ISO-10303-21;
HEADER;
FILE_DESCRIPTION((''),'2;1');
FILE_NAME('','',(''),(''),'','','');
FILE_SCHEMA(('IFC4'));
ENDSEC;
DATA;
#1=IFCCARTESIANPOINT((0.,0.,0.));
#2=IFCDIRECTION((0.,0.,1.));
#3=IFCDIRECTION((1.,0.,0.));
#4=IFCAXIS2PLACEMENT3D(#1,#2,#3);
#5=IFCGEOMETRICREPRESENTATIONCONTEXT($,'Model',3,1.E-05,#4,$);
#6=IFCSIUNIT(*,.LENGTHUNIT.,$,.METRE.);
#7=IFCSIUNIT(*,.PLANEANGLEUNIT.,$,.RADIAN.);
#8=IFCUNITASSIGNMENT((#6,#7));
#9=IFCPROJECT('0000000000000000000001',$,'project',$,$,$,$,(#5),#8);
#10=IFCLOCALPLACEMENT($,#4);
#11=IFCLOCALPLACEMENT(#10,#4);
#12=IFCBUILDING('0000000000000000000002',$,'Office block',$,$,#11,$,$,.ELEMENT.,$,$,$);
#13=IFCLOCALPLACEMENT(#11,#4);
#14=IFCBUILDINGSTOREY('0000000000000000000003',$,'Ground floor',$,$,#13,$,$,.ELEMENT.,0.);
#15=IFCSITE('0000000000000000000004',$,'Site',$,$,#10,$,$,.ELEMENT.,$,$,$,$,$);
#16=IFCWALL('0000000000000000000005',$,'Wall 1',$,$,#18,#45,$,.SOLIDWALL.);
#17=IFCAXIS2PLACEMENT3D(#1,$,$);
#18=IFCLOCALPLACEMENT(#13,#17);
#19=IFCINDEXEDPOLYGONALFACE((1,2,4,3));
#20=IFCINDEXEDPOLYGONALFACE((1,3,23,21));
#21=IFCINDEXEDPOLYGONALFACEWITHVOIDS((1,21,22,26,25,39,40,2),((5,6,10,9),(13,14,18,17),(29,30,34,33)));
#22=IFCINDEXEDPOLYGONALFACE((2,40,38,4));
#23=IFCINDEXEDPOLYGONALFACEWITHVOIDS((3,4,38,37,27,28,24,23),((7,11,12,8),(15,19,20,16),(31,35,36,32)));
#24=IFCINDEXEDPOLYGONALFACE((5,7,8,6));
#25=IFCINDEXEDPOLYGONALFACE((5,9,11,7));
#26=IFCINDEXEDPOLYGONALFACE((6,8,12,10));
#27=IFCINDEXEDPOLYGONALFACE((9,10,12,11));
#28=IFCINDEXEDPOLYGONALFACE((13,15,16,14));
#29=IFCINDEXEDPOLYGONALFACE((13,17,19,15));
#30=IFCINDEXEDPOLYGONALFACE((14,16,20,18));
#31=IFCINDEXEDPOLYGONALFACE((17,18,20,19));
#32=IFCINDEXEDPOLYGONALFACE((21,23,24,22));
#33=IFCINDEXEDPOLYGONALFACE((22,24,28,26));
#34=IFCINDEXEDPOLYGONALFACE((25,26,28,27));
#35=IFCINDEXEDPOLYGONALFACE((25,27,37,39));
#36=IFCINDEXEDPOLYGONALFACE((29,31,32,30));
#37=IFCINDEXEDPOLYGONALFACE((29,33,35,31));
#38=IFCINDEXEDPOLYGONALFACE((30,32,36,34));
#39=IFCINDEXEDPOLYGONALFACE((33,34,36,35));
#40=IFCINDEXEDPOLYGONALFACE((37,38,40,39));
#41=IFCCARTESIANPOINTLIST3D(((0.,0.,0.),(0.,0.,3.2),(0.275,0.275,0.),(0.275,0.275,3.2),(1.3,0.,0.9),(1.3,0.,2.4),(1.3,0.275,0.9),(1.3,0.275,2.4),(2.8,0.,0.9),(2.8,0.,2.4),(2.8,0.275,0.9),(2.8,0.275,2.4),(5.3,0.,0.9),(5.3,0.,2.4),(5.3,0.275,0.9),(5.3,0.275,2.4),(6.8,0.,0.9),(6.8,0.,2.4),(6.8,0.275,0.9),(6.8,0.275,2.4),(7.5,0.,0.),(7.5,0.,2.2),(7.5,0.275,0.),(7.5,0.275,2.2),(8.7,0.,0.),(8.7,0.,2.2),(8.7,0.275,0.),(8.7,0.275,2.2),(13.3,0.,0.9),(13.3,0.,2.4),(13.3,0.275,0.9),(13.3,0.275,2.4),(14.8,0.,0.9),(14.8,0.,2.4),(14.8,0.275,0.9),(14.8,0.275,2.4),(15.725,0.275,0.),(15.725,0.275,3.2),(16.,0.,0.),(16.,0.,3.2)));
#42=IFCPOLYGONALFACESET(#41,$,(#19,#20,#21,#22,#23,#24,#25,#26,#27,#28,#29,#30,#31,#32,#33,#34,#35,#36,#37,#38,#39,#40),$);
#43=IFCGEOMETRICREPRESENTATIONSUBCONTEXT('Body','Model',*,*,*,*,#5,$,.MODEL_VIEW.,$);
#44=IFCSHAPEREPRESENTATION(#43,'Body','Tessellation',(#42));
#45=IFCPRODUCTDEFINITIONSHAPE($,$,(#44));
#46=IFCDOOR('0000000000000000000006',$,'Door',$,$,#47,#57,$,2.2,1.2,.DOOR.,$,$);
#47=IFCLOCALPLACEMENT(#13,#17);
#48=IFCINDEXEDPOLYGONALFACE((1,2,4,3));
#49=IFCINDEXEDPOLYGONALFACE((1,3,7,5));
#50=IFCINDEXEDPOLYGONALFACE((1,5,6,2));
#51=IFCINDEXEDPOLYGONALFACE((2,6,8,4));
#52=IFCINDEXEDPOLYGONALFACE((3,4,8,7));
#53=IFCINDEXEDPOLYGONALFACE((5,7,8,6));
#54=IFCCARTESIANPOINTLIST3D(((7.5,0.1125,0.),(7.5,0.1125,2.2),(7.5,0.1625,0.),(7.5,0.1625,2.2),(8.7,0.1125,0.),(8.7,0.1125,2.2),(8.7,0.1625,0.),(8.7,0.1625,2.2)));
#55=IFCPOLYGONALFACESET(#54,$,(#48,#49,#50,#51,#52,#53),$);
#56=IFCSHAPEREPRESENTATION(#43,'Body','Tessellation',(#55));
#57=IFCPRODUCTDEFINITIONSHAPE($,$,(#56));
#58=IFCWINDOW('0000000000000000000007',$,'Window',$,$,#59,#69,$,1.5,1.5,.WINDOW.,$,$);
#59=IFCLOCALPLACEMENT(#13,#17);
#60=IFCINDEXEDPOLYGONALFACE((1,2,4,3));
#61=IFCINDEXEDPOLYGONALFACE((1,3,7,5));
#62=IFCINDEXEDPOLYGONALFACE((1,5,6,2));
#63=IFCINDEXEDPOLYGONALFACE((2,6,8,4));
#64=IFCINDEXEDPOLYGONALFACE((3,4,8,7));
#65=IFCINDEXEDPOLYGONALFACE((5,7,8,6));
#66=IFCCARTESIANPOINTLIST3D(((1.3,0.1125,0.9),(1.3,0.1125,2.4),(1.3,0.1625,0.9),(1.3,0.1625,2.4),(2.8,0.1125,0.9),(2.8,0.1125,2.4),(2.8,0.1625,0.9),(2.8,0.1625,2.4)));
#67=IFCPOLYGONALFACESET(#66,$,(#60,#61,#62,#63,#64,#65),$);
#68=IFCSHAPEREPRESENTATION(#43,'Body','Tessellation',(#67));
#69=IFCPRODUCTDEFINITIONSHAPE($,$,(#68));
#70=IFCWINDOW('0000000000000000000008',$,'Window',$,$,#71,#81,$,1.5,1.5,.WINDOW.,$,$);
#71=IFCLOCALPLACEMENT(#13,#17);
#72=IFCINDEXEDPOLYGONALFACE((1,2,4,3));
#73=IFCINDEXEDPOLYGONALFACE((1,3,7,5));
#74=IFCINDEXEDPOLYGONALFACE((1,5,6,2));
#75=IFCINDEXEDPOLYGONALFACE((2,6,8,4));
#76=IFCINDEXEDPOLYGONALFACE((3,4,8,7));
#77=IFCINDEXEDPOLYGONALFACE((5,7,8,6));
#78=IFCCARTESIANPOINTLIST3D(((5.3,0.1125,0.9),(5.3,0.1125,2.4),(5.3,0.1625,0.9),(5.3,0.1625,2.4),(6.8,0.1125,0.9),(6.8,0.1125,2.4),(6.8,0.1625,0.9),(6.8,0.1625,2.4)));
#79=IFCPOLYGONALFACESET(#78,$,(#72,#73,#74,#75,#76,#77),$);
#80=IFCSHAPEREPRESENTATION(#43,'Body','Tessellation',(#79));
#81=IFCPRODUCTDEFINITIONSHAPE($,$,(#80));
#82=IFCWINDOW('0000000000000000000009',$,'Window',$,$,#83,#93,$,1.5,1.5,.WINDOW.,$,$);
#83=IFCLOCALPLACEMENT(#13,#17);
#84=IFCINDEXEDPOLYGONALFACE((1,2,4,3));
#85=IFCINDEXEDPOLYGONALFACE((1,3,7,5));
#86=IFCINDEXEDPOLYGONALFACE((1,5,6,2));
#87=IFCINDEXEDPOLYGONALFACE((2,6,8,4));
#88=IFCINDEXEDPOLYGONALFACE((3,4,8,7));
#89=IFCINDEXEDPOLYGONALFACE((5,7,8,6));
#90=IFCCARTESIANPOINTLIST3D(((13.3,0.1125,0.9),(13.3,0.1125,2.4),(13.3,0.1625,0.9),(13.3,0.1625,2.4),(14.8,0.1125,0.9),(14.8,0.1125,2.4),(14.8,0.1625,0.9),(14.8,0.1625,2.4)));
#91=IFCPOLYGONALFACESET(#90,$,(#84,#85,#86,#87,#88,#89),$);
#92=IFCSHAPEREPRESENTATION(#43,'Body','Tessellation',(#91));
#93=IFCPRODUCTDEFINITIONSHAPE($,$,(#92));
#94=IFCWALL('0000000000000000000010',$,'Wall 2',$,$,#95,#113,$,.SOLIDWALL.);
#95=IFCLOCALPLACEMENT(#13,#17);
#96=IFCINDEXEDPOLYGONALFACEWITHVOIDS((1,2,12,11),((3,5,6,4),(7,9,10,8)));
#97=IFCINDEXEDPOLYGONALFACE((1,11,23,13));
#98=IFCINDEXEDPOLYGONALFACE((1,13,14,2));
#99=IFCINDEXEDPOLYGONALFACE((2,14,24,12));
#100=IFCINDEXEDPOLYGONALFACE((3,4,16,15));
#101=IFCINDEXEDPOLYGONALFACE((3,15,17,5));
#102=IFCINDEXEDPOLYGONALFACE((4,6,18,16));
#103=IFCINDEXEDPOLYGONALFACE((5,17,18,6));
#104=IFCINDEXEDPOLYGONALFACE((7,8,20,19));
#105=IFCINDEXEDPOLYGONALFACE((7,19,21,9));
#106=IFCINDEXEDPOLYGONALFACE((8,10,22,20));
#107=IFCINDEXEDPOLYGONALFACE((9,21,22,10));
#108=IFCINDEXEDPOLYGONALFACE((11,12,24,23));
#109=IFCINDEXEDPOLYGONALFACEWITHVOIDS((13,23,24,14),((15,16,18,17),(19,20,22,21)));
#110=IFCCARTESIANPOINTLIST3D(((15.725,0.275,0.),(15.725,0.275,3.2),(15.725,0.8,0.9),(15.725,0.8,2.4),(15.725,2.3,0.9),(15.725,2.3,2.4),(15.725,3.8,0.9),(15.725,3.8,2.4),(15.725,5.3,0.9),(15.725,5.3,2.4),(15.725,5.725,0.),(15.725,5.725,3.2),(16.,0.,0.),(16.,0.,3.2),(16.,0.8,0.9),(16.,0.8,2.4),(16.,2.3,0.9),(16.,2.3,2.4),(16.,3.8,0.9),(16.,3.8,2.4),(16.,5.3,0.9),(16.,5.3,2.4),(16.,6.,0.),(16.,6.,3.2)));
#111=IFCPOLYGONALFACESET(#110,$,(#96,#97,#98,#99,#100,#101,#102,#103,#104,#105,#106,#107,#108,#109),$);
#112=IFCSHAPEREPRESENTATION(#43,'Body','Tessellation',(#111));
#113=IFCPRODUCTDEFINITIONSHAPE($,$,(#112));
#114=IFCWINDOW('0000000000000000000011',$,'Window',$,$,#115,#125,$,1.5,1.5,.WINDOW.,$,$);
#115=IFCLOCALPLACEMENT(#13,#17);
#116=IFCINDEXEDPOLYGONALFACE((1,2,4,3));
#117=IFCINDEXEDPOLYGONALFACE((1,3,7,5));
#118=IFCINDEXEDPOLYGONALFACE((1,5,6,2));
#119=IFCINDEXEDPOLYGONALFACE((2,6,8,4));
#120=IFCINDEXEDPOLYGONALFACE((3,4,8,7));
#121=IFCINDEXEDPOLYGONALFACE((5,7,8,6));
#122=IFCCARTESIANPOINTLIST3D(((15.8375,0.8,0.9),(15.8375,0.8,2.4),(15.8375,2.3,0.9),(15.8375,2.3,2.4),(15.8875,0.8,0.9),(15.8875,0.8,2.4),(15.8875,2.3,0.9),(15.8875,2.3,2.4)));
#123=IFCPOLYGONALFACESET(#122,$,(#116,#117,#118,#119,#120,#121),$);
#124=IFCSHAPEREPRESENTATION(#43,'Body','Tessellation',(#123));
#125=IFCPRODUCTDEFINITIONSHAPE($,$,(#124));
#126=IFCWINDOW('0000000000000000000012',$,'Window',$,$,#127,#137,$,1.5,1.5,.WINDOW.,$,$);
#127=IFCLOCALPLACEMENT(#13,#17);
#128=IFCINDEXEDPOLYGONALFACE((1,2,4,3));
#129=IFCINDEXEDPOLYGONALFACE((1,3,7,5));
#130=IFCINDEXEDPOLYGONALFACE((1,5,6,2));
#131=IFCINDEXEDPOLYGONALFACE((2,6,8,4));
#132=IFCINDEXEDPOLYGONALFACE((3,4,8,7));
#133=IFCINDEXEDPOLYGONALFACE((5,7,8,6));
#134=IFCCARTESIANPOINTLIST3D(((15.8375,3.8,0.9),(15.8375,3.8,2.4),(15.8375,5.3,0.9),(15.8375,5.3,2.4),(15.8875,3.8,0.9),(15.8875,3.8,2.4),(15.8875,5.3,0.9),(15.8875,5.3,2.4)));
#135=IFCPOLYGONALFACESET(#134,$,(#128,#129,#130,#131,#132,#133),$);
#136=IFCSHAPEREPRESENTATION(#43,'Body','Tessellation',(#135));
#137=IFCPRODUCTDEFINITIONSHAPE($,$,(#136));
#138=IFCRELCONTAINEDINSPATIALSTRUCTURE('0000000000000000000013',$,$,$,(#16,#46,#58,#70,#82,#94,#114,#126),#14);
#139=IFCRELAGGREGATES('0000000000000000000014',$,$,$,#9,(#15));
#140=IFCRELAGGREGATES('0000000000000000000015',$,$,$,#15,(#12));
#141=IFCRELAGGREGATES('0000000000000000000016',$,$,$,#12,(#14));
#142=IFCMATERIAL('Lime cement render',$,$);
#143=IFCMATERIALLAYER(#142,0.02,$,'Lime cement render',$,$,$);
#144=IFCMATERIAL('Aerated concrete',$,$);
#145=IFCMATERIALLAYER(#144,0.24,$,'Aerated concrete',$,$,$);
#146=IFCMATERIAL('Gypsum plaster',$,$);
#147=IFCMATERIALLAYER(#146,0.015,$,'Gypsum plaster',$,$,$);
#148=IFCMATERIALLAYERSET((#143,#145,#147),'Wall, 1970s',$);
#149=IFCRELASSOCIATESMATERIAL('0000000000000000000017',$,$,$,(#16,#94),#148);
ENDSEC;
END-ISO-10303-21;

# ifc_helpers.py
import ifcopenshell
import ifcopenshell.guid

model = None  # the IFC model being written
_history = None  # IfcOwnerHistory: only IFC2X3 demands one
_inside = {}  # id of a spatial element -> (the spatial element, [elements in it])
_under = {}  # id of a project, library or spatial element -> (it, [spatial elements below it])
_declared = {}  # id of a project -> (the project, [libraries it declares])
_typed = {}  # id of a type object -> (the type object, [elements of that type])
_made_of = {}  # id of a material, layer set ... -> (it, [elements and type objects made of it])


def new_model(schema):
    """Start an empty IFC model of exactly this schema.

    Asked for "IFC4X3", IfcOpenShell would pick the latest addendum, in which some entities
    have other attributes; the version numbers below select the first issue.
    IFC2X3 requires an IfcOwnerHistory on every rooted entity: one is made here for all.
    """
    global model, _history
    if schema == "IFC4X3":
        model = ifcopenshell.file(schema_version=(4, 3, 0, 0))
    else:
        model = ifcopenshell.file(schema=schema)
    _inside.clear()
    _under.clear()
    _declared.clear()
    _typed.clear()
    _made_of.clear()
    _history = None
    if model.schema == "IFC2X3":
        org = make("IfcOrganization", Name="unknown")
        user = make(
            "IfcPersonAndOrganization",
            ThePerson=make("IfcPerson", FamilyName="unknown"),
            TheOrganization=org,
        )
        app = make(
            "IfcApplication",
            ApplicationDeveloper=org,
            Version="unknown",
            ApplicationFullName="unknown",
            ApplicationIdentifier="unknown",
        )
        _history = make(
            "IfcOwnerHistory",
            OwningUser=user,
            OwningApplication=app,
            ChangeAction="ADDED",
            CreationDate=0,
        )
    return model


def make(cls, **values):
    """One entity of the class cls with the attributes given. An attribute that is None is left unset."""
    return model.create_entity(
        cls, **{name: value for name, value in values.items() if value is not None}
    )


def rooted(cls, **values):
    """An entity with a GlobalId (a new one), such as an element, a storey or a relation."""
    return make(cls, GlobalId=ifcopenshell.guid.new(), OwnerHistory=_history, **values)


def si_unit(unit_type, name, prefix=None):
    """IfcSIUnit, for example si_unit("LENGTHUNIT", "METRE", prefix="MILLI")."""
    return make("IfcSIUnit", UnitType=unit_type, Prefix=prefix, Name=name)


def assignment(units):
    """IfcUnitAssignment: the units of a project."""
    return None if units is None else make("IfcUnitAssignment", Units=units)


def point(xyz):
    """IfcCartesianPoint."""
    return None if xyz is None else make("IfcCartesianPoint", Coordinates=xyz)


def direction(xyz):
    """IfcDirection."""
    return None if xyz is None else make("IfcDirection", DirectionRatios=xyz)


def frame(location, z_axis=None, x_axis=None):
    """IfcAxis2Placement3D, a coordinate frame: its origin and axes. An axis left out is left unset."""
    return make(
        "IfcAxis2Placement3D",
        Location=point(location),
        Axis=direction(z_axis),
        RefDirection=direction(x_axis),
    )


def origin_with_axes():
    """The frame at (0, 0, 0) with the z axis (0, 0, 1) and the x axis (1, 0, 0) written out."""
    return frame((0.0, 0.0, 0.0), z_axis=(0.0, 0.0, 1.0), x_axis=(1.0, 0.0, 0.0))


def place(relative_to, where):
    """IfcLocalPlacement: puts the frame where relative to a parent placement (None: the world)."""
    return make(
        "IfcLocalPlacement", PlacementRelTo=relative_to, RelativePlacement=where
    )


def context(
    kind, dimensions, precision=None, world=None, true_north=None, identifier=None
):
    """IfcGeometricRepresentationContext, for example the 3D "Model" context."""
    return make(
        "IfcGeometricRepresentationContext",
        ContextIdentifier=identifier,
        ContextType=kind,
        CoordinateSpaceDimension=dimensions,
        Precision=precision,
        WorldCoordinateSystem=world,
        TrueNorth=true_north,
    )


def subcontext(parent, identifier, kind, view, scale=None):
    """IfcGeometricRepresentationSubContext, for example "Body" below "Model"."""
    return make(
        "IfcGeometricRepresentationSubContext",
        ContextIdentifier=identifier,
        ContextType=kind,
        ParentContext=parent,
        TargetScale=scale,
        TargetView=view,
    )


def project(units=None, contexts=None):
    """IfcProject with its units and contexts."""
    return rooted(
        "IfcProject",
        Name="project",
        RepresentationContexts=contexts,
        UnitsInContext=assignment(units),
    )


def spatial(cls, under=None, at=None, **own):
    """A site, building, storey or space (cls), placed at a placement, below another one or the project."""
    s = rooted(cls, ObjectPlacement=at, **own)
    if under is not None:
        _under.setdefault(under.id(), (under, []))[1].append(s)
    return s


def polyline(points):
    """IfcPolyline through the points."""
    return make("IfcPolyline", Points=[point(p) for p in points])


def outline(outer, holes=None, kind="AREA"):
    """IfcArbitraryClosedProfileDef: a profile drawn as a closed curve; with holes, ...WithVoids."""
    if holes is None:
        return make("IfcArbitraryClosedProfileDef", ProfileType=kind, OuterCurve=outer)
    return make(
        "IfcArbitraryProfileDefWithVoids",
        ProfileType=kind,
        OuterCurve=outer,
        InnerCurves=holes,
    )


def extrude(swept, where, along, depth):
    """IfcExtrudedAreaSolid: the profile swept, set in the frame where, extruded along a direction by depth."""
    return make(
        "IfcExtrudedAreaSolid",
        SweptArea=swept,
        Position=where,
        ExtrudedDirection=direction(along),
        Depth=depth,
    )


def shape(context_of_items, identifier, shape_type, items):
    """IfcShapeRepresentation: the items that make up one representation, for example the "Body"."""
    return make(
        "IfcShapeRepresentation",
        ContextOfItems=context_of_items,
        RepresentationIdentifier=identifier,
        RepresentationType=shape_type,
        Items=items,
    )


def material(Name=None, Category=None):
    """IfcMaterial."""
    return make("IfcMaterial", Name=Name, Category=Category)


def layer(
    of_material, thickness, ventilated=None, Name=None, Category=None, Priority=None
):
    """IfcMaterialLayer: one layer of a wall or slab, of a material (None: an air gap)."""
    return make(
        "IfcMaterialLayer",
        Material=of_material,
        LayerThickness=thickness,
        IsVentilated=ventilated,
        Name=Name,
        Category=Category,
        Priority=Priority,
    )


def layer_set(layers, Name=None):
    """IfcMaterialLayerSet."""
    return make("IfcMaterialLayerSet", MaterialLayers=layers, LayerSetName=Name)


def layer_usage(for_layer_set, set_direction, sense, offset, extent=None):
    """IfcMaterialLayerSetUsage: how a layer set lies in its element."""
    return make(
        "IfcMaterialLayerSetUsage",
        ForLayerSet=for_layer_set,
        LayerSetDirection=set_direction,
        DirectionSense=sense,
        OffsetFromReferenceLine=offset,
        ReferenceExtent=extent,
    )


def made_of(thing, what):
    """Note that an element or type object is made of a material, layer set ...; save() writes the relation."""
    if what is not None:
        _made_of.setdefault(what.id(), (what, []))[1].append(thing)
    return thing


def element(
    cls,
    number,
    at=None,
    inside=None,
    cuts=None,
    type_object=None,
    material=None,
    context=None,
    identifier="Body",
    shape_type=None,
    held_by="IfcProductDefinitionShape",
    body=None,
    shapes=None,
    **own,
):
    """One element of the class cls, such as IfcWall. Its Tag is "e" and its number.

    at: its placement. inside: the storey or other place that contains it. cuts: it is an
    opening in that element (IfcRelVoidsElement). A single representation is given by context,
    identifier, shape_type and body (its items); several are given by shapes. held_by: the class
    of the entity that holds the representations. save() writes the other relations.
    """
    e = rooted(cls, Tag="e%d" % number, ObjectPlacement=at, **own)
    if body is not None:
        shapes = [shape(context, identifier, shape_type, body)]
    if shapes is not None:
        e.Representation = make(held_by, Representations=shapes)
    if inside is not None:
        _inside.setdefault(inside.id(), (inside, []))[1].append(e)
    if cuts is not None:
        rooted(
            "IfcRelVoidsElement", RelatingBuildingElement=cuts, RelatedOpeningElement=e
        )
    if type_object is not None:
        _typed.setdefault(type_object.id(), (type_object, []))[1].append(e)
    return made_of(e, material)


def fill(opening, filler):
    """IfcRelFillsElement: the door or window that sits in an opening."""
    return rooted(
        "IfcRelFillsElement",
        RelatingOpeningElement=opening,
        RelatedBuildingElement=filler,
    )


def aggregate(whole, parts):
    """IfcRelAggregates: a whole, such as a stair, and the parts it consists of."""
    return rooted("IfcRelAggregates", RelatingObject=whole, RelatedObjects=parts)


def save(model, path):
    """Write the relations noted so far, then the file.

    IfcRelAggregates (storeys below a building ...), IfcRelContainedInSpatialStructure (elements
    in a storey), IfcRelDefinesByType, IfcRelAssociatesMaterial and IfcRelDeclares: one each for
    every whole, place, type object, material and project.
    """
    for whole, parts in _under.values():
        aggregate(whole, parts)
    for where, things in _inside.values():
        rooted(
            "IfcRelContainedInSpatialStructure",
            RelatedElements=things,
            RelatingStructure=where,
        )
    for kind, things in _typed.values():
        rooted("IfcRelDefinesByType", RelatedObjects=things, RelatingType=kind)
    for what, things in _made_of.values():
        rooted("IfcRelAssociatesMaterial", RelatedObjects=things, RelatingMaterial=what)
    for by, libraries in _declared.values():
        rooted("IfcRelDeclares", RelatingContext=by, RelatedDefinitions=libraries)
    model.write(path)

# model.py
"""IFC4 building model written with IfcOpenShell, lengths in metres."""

from ifc_helpers import new_model, si_unit, frame, origin_with_axes, place, context, subcontext, project, spatial, polyline, outline, extrude, material, layer, layer_set, layer_usage, element, fill, save


model = new_model("IFC4")

# Units and contexts
model_context = context("Model", 3, precision=1e-05, world=origin_with_axes())
body_context = subcontext(model_context, "Body", "Model", "MODEL_VIEW")
ifc_project = project(units=[si_unit("LENGTHUNIT", "METRE"), si_unit("PLANEANGLEUNIT", "RADIAN")], contexts=[model_context])

# Site, building, storey
site_placement = place(None, origin_with_axes())
site = spatial("IfcSite", under=ifc_project, at=site_placement, Name="Site", CompositionType="ELEMENT")
building_placement = place(site_placement, origin_with_axes())
building = spatial("IfcBuilding", under=site, at=building_placement, Name="Office block", CompositionType="ELEMENT")
storey_placement = place(building_placement, origin_with_axes())
storey = spatial("IfcBuildingStorey", under=building, at=storey_placement, Name="Ground floor", CompositionType="ELEMENT", Elevation=0.0)

# Wall, openings, door, windows
ifc_material_1 = material(Name="Lime cement render")
ifc_layer_1 = layer(ifc_material_1, 0.02, Name="Lime cement render")
ifc_material_2 = material(Name="Aerated concrete")
ifc_layer_2 = layer(ifc_material_2, 0.24, Name="Aerated concrete")
ifc_material_3 = material(Name="Gypsum plaster")
ifc_layer_3 = layer(ifc_material_3, 0.015, Name="Gypsum plaster")
ifc_layer_set = layer_set([ifc_layer_1, ifc_layer_2, ifc_layer_3], Name="Wall, 1970s")
ifc_layer_usage_1 = layer_usage(ifc_layer_set, "AXIS2", "NEGATIVE", 0.0)
wall_1_placement = place(storey_placement, origin_with_axes())
wall_1 = element("IfcWall", 1, at=wall_1_placement, inside=storey, material=ifc_layer_usage_1, Name="Wall 1", PredefinedType="SOLIDWALL", context=body_context, shape_type="SweptSolid", body=[
    extrude(outline(polyline([(0.0, 0.0), (16.0, 0.0), (15.725, 0.275), (0.275, 0.275), (0.0, 0.0)])), origin_with_axes(), (0.0, 0.0, 1.0), 3.2),
])
opening_1_placement = place(storey_placement, origin_with_axes())
opening_1 = element("IfcOpeningElement", 2, at=opening_1_placement, cuts=wall_1, PredefinedType="OPENING", context=body_context, shape_type="SweptSolid", body=[
    extrude(outline(polyline([(7.5, -0.01), (8.7, -0.01), (8.7, 0.285), (7.5, 0.285), (7.5, -0.01)])), origin_with_axes(), (0.0, 0.0, 1.0), 2.2),
])
opening_2_placement = place(storey_placement, origin_with_axes())
opening_2 = element("IfcOpeningElement", 3, at=opening_2_placement, cuts=wall_1, PredefinedType="OPENING", context=body_context, shape_type="SweptSolid", body=[
    extrude(outline(polyline([(1.3, -0.01), (2.8, -0.01), (2.8, 0.285), (1.3, 0.285), (1.3, -0.01)])), frame((0.0, 0.0, 0.9), z_axis=(0.0, 0.0, 1.0), x_axis=(1.0, 0.0, 0.0)), (0.0, 0.0, 1.0), 1.5),
])
opening_3_placement = place(storey_placement, origin_with_axes())
opening_3 = element("IfcOpeningElement", 4, at=opening_3_placement, cuts=wall_1, PredefinedType="OPENING", context=body_context, shape_type="SweptSolid", body=[
    extrude(outline(polyline([(5.3, -0.01), (6.8, -0.01), (6.8, 0.285), (5.3, 0.285), (5.3, -0.01)])), frame((0.0, 0.0, 0.9), z_axis=(0.0, 0.0, 1.0), x_axis=(1.0, 0.0, 0.0)), (0.0, 0.0, 1.0), 1.5),
])
opening_4_placement = place(storey_placement, origin_with_axes())
opening_4 = element("IfcOpeningElement", 5, at=opening_4_placement, cuts=wall_1, PredefinedType="OPENING", context=body_context, shape_type="SweptSolid", body=[
    extrude(outline(polyline([(13.3, -0.01), (14.8, -0.01), (14.8, 0.285), (13.3, 0.285), (13.3, -0.01)])), frame((0.0, 0.0, 0.9), z_axis=(0.0, 0.0, 1.0), x_axis=(1.0, 0.0, 0.0)), (0.0, 0.0, 1.0), 1.5),
])
door_placement = place(storey_placement, origin_with_axes())
door = element("IfcDoor", 6, at=door_placement, inside=storey, Name="Door", OverallHeight=2.2, OverallWidth=1.2, PredefinedType="DOOR", context=body_context, shape_type="SweptSolid", body=[
    extrude(outline(polyline([(7.5, 0.1125), (8.7, 0.1125), (8.7, 0.1625), (7.5, 0.1625), (7.5, 0.1125)])), origin_with_axes(), (0.0, 0.0, 1.0), 2.2),
])
fill(opening_1, door)
window_1_placement = place(storey_placement, origin_with_axes())
window_1 = element("IfcWindow", 7, at=window_1_placement, inside=storey, Name="Window", OverallHeight=1.5, OverallWidth=1.5, PredefinedType="WINDOW", context=body_context, shape_type="SweptSolid", body=[
    extrude(outline(polyline([(1.3, 0.1125), (2.8, 0.1125), (2.8, 0.1625), (1.3, 0.1625), (1.3, 0.1125)])), frame((0.0, 0.0, 0.9), z_axis=(0.0, 0.0, 1.0), x_axis=(1.0, 0.0, 0.0)), (0.0, 0.0, 1.0), 1.5),
])
fill(opening_2, window_1)
window_2_placement = place(storey_placement, origin_with_axes())
window_2 = element("IfcWindow", 8, at=window_2_placement, inside=storey, Name="Window", OverallHeight=1.5, OverallWidth=1.5, PredefinedType="WINDOW", context=body_context, shape_type="SweptSolid", body=[
    extrude(outline(polyline([(5.3, 0.1125), (6.8, 0.1125), (6.8, 0.1625), (5.3, 0.1625), (5.3, 0.1125)])), frame((0.0, 0.0, 0.9), z_axis=(0.0, 0.0, 1.0), x_axis=(1.0, 0.0, 0.0)), (0.0, 0.0, 1.0), 1.5),
])
fill(opening_3, window_2)
window_3_placement = place(storey_placement, origin_with_axes())
window_3 = element("IfcWindow", 9, at=window_3_placement, inside=storey, Name="Window", OverallHeight=1.5, OverallWidth=1.5, PredefinedType="WINDOW", context=body_context, shape_type="SweptSolid", body=[
    extrude(outline(polyline([(13.3, 0.1125), (14.8, 0.1125), (14.8, 0.1625), (13.3, 0.1625), (13.3, 0.1125)])), frame((0.0, 0.0, 0.9), z_axis=(0.0, 0.0, 1.0), x_axis=(1.0, 0.0, 0.0)), (0.0, 0.0, 1.0), 1.5),
])
fill(opening_4, window_3)

# Wall, openings, windows
ifc_layer_usage_2 = layer_usage(ifc_layer_set, "AXIS2", "NEGATIVE", 0.0)
wall_2_placement = place(storey_placement, origin_with_axes())
wall_2 = element("IfcWall", 10, at=wall_2_placement, inside=storey, material=ifc_layer_usage_2, Name="Wall 2", PredefinedType="SOLIDWALL", context=body_context, shape_type="SweptSolid", body=[
    extrude(outline(polyline([(16.0, 0.0), (16.0, 6.0), (15.725, 5.725), (15.725, 0.275), (16.0, 0.0)])), origin_with_axes(), (0.0, 0.0, 1.0), 3.2),
])
opening_5_placement = place(storey_placement, origin_with_axes())
opening_5 = element("IfcOpeningElement", 11, at=opening_5_placement, cuts=wall_2, PredefinedType="OPENING", context=body_context, shape_type="SweptSolid", body=[
    extrude(outline(polyline([(16.01, 0.8), (16.01, 2.3), (15.715, 2.3), (15.715, 0.8), (16.01, 0.8)])), frame((0.0, 0.0, 0.9), z_axis=(0.0, 0.0, 1.0), x_axis=(1.0, 0.0, 0.0)), (0.0, 0.0, 1.0), 1.5),
])
opening_6_placement = place(storey_placement, origin_with_axes())
opening_6 = element("IfcOpeningElement", 12, at=opening_6_placement, cuts=wall_2, PredefinedType="OPENING", context=body_context, shape_type="SweptSolid", body=[
    extrude(outline(polyline([(16.01, 3.8), (16.01, 5.3), (15.715, 5.3), (15.715, 3.8), (16.01, 3.8)])), frame((0.0, 0.0, 0.9), z_axis=(0.0, 0.0, 1.0), x_axis=(1.0, 0.0, 0.0)), (0.0, 0.0, 1.0), 1.5),
])
window_4_placement = place(storey_placement, origin_with_axes())
window_4 = element("IfcWindow", 13, at=window_4_placement, inside=storey, Name="Window", OverallHeight=1.5, OverallWidth=1.5, PredefinedType="WINDOW", context=body_context, shape_type="SweptSolid", body=[
    extrude(outline(polyline([(15.8875, 0.8), (15.8875, 2.3), (15.8375, 2.3), (15.8375, 0.8), (15.8875, 0.8)])), frame((0.0, 0.0, 0.9), z_axis=(0.0, 0.0, 1.0), x_axis=(1.0, 0.0, 0.0)), (0.0, 0.0, 1.0), 1.5),
])
fill(opening_5, window_4)
window_5_placement = place(storey_placement, origin_with_axes())
window_5 = element("IfcWindow", 14, at=window_5_placement, inside=storey, Name="Window", OverallHeight=1.5, OverallWidth=1.5, PredefinedType="WINDOW", context=body_context, shape_type="SweptSolid", body=[
    extrude(outline(polyline([(15.8875, 3.8), (15.8875, 5.3), (15.8375, 5.3), (15.8375, 3.8), (15.8875, 3.8)])), frame((0.0, 0.0, 0.9), z_axis=(0.0, 0.0, 1.0), x_axis=(1.0, 0.0, 0.0)), (0.0, 0.0, 1.0), 1.5),
])
fill(opening_6, window_5)

save(model, "model.ifc")
